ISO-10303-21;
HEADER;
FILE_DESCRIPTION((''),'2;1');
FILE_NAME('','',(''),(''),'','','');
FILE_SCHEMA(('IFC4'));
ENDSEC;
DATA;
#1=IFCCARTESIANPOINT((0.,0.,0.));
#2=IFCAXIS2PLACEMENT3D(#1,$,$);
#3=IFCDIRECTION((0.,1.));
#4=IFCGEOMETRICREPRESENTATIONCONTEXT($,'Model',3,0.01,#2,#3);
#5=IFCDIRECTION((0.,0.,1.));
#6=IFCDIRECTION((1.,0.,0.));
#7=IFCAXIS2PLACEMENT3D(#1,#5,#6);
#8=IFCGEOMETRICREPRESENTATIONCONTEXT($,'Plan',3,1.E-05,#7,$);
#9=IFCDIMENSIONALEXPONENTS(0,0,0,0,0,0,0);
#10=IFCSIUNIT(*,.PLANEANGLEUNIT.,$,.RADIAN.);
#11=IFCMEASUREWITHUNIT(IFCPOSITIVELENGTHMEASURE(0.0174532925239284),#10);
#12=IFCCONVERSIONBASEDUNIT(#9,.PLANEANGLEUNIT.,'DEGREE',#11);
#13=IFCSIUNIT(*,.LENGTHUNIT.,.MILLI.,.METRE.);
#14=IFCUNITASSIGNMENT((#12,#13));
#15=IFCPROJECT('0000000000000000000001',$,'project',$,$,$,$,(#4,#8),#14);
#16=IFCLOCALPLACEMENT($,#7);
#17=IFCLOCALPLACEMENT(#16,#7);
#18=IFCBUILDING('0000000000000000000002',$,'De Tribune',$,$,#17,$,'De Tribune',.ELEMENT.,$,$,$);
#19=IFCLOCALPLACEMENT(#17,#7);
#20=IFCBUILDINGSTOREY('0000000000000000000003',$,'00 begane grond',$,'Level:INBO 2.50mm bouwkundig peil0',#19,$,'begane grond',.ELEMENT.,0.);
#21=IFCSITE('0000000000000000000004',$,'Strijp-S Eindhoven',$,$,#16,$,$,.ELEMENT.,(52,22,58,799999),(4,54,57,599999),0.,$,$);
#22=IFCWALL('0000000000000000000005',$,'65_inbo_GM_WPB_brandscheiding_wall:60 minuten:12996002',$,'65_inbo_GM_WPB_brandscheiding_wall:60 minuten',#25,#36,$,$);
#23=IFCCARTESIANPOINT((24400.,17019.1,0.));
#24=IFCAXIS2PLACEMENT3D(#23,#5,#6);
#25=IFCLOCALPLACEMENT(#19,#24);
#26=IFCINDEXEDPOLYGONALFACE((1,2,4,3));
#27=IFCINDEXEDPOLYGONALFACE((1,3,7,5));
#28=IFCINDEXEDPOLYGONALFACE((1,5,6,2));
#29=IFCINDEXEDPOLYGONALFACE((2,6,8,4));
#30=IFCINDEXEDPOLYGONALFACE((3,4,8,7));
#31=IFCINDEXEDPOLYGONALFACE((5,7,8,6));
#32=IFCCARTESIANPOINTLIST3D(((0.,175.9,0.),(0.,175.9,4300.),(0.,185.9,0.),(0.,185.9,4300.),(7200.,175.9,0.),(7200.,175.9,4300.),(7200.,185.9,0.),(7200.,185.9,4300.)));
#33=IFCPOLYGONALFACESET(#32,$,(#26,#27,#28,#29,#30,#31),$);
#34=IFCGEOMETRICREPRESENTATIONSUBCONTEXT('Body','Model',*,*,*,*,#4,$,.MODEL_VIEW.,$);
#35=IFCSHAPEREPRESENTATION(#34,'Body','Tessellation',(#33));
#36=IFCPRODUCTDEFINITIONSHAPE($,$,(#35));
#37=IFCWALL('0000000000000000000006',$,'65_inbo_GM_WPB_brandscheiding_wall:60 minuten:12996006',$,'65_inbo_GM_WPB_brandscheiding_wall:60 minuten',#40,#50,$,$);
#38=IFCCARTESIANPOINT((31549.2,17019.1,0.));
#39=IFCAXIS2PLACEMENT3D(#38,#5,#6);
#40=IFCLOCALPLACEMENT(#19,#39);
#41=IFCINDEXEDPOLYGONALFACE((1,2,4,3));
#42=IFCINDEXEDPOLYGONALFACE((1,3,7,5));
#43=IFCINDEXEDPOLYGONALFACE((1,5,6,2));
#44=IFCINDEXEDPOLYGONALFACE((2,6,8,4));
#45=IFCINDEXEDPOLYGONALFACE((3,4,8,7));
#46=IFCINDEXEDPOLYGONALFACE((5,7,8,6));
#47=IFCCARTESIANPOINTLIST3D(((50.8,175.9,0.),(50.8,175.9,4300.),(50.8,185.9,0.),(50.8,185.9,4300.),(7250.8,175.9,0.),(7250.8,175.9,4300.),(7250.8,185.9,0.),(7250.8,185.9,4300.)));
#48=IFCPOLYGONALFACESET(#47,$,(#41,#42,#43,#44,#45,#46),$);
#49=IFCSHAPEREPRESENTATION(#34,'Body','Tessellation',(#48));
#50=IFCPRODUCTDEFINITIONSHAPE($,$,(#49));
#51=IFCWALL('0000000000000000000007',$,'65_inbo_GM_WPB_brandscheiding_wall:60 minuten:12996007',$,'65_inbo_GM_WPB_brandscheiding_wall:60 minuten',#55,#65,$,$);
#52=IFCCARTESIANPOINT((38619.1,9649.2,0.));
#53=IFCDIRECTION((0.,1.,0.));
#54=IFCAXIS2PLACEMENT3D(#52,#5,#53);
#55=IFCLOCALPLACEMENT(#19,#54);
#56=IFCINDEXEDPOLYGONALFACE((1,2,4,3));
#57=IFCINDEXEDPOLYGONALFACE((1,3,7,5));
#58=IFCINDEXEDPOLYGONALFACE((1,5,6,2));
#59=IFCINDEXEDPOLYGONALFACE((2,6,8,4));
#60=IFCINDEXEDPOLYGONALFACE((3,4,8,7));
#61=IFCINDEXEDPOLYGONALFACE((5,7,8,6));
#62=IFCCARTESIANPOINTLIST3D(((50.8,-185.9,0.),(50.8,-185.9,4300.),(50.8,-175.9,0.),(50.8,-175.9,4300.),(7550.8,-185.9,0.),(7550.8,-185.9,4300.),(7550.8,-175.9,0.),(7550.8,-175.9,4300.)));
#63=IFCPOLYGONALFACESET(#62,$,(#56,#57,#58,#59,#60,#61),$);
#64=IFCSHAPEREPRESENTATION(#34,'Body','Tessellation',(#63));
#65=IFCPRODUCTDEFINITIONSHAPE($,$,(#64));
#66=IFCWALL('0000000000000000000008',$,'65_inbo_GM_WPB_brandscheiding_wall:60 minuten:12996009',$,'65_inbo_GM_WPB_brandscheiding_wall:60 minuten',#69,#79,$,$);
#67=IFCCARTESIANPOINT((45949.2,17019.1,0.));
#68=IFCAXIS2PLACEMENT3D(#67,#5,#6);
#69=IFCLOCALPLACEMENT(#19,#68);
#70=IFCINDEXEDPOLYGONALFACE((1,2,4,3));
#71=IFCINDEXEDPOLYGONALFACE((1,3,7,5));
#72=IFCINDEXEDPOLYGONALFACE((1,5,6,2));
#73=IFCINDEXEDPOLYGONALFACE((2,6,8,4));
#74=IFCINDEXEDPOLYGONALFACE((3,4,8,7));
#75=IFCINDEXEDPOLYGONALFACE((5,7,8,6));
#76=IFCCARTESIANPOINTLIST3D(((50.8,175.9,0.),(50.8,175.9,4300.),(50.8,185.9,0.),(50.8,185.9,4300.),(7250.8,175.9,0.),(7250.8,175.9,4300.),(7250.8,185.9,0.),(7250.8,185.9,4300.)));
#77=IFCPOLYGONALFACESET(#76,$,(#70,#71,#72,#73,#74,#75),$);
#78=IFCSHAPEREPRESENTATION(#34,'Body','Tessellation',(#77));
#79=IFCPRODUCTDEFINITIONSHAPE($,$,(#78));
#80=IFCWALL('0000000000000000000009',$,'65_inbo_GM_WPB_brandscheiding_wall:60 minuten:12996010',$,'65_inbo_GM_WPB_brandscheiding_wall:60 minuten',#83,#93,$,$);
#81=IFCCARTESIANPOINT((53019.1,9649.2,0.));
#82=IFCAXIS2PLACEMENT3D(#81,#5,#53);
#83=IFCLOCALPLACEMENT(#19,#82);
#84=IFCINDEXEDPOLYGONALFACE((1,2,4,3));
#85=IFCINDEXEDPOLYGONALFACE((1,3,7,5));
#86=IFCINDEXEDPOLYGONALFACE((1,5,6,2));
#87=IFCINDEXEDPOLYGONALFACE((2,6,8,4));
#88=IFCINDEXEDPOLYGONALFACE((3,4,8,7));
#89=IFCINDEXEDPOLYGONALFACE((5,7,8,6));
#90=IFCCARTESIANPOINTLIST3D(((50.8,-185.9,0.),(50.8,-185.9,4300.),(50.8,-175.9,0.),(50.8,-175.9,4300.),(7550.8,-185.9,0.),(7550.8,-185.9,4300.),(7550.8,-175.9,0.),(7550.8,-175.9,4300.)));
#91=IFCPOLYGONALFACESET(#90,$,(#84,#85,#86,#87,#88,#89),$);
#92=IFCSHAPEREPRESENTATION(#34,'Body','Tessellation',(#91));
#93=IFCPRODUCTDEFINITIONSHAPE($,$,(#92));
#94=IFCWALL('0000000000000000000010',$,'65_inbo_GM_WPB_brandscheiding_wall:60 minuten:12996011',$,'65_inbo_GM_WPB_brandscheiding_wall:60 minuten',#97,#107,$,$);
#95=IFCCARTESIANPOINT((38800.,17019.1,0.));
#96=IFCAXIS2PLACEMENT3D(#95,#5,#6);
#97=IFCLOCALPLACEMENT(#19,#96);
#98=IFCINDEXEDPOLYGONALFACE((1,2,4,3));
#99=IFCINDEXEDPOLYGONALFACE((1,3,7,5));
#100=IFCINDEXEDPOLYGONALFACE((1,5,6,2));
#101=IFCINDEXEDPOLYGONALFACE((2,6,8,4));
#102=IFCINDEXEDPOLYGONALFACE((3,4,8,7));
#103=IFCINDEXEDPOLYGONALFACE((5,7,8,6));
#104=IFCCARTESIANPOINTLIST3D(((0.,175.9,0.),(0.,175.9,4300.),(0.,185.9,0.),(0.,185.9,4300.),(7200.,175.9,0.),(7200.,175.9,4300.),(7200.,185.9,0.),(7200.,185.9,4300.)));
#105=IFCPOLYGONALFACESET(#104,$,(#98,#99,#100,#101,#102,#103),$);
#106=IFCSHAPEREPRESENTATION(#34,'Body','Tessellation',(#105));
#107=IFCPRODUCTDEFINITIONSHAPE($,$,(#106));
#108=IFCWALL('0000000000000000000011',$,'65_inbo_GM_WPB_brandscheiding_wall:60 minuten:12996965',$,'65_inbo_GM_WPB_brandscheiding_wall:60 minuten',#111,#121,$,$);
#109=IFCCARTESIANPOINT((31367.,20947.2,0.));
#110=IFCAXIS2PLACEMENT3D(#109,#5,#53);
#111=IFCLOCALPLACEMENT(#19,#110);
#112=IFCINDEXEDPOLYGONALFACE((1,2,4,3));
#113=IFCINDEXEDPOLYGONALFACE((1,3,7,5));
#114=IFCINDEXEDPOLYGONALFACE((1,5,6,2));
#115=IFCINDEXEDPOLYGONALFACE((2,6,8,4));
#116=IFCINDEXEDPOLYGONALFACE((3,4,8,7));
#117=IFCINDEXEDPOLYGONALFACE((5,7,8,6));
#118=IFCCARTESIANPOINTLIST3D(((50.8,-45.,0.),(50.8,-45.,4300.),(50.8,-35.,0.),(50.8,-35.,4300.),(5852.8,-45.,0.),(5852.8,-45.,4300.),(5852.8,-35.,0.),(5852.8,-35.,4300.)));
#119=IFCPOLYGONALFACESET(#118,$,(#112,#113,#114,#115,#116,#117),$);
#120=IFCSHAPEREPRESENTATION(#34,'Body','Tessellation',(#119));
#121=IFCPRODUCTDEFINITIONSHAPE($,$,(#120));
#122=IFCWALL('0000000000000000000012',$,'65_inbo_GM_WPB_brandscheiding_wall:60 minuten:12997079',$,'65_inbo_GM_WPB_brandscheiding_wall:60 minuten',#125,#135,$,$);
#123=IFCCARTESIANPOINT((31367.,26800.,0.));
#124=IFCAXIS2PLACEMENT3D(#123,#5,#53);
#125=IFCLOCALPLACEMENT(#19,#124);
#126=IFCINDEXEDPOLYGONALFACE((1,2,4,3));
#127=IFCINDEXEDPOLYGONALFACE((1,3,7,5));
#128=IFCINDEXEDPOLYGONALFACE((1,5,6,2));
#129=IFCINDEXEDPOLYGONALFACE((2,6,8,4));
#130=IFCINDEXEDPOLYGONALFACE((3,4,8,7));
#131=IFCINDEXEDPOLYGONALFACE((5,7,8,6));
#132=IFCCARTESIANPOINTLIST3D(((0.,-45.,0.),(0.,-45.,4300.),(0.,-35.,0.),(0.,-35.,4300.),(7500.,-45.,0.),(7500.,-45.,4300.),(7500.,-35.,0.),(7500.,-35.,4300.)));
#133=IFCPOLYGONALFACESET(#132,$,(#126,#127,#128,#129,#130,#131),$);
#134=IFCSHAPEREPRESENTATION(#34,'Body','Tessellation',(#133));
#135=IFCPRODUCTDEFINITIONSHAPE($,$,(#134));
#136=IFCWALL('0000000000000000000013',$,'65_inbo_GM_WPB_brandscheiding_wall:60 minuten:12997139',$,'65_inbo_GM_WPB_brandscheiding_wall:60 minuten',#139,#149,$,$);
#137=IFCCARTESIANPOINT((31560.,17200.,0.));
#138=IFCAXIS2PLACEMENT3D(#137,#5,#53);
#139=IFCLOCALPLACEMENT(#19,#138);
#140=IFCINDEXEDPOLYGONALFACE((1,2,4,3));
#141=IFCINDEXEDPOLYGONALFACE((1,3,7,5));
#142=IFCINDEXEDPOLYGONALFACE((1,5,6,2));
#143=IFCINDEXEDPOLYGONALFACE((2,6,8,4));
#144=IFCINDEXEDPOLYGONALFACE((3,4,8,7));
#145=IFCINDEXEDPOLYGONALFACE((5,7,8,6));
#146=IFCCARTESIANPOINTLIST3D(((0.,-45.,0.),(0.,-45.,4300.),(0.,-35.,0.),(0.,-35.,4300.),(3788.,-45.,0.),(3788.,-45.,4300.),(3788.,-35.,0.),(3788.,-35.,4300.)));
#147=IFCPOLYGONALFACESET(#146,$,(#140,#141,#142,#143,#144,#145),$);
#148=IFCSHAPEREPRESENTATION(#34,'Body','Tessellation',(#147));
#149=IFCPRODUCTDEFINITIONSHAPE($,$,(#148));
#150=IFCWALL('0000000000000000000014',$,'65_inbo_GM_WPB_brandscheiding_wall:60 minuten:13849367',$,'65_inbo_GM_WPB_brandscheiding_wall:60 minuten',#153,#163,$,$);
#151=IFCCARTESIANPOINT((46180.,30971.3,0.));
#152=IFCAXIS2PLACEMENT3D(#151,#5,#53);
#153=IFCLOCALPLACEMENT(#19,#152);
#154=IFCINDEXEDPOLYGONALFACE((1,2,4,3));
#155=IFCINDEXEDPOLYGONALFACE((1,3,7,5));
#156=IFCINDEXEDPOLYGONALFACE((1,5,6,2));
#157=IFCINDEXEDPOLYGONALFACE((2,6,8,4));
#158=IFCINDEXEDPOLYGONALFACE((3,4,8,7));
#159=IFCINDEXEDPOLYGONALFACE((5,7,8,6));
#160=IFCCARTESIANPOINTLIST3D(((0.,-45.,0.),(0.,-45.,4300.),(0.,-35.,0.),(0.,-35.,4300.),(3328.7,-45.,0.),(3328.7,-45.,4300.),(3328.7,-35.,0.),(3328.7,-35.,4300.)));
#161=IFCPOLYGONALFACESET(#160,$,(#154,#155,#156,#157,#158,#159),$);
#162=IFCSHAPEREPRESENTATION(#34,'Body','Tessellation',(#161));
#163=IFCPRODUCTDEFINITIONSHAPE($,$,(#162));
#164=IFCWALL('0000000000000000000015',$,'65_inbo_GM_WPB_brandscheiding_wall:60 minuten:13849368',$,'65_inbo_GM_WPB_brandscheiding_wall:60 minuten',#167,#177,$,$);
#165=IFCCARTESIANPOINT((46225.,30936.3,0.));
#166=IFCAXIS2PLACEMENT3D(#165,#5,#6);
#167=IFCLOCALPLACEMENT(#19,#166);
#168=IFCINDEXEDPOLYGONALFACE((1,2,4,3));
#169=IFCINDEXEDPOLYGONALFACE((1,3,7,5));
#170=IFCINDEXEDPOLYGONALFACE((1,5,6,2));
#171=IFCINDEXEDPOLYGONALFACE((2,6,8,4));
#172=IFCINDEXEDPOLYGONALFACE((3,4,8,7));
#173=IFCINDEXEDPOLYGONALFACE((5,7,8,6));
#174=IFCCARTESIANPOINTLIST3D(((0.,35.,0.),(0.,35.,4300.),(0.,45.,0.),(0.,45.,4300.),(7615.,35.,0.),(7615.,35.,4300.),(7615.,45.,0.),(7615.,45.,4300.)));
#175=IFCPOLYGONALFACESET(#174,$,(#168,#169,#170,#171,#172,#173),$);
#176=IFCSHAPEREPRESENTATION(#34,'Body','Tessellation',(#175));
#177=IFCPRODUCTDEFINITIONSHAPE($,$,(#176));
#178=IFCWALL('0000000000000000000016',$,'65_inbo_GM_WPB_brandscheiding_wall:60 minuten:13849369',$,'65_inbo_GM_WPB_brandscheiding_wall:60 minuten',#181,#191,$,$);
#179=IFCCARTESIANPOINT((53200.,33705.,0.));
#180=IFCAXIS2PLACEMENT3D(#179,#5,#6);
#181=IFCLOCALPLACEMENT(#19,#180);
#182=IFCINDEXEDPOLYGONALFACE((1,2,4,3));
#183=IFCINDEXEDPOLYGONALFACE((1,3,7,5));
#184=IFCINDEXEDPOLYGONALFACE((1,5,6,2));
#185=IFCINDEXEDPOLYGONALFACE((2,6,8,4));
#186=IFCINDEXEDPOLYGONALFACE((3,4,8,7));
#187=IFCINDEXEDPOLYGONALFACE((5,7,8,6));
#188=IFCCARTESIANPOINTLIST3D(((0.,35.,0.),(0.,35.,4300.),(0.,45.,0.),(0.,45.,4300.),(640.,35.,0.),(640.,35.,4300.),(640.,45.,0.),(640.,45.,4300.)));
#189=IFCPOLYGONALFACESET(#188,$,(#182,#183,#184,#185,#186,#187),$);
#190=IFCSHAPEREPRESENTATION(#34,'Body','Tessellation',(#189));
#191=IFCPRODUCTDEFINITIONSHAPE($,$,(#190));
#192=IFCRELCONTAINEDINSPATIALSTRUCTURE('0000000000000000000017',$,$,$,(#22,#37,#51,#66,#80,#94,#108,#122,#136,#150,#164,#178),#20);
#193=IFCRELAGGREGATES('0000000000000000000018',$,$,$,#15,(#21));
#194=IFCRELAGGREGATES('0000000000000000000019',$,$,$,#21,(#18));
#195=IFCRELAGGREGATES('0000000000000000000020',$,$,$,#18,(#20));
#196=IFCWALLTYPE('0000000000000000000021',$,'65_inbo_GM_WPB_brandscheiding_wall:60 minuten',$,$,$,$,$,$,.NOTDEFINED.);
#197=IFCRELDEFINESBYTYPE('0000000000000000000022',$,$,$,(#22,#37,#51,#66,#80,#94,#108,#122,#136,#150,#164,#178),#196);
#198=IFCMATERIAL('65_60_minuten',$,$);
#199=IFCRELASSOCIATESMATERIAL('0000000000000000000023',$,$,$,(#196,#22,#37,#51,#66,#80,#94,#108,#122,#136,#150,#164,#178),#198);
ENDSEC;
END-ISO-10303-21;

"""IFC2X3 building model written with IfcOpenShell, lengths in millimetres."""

from ifc_helpers import new_model, entity, si_unit, converted_unit, direction, frame, frame_2d, origin, origin_with_axes, origin_2d_with_axis, place, context, subcontext, project, spatial, rectangle, extrude, material, type_object, element, save


model = new_model("IFC2X3")

# Units and contexts
model_context = context("Model", 3, precision=0.01, world=origin(), true_north=direction((0.0, 1.0)))
plan_context = context("Plan", 3, precision=1e-05, world=origin_with_axes())
body_context = subcontext(model_context, "Body", "Model", "MODEL_VIEW")
ifc_project = project(units=[converted_unit("PLANEANGLEUNIT", "DEGREE", entity("IfcPositiveLengthMeasure", 0.0174532925239284), si_unit("PLANEANGLEUNIT", "RADIAN"), dimensions=[0, 0, 0, 0, 0, 0, 0]), si_unit("LENGTHUNIT", "METRE", prefix="MILLI")], contexts=[model_context, plan_context])

# Site, building, storey
site_placement = place(None, origin_with_axes())
site = spatial("IfcSite", under=ifc_project, at=site_placement, Name="Strijp-S Eindhoven", CompositionType="ELEMENT", RefLatitude=(52, 22, 58, 799999), RefLongitude=(4, 54, 57, 599999), RefElevation=0.0)
building_placement = place(site_placement, origin_with_axes())
building = spatial("IfcBuilding", under=site, at=building_placement, Name="De Tribune", LongName="De Tribune", CompositionType="ELEMENT")
storey_placement = place(building_placement, origin_with_axes())
storey = spatial("IfcBuildingStorey", under=building, at=storey_placement, Name="00 begane grond", ObjectType="Level:INBO 2.50mm bouwkundig peil0", LongName="begane grond", CompositionType="ELEMENT", Elevation=0.0)

# Walls
ifc_material = material(Name="65_60_minuten")
wall_type = type_object("IfcWallType", Name="65_inbo_GM_WPB_brandscheiding_wall:60 minuten", PredefinedType="NOTDEFINED", material=ifc_material)
wall_1_placement = place(storey_placement, frame((24400.0, 17019.1, 0.0), z_axis=(0.0, 0.0, 1.0), x_axis=(1.0, 0.0, 0.0)))
element("IfcWall", 1, at=wall_1_placement, inside=storey, type_object=wall_type, material=ifc_material, Name="65_inbo_GM_WPB_brandscheiding_wall:60 minuten:12996002", ObjectType="65_inbo_GM_WPB_brandscheiding_wall:60 minuten", context=body_context, shape_type="SweptSolid", body=[
    extrude(rectangle(XDim=10.0, YDim=7200.0, at=frame_2d((0.0, 0.0), x_axis=(1.0, 0.0))), frame((3600.0, 180.9, 0.0), z_axis=(0.0, 0.0, 1.0), x_axis=(0.0, -1.0, 0.0)), (0.0, 0.0, 1.0), 4300.0),
])
wall_2_placement = place(storey_placement, frame((31549.2, 17019.1, 0.0), z_axis=(0.0, 0.0, 1.0), x_axis=(1.0, 0.0, 0.0)))
element("IfcWall", 2, at=wall_2_placement, inside=storey, type_object=wall_type, material=ifc_material, Name="65_inbo_GM_WPB_brandscheiding_wall:60 minuten:12996006", ObjectType="65_inbo_GM_WPB_brandscheiding_wall:60 minuten", context=body_context, shape_type="SweptSolid", body=[
    extrude(rectangle(XDim=7200.0, YDim=10.0, at=origin_2d_with_axis()), frame((3650.8, 180.9, 0.0), z_axis=(0.0, 0.0, 1.0), x_axis=(-1.0, 0.0, 0.0)), (0.0, 0.0, 1.0), 4300.0),
])
wall_3_placement = place(storey_placement, frame((38619.1, 9649.2, 0.0), z_axis=(0.0, 0.0, 1.0), x_axis=(0.0, 1.0, 0.0)))
element("IfcWall", 3, at=wall_3_placement, inside=storey, type_object=wall_type, material=ifc_material, Name="65_inbo_GM_WPB_brandscheiding_wall:60 minuten:12996007", ObjectType="65_inbo_GM_WPB_brandscheiding_wall:60 minuten", context=body_context, shape_type="SweptSolid", body=[
    extrude(rectangle(XDim=10.0, YDim=7500.0, at=frame_2d((0.0, 0.0), x_axis=(1.0, 0.0))), frame((3800.8, -180.9, 0.0), z_axis=(0.0, 0.0, 1.0), x_axis=(0.0, 1.0, 0.0)), (0.0, 0.0, 1.0), 4300.0),
])
wall_4_placement = place(storey_placement, frame((45949.2, 17019.1, 0.0), z_axis=(0.0, 0.0, 1.0), x_axis=(1.0, 0.0, 0.0)))
element("IfcWall", 4, at=wall_4_placement, inside=storey, type_object=wall_type, material=ifc_material, Name="65_inbo_GM_WPB_brandscheiding_wall:60 minuten:12996009", ObjectType="65_inbo_GM_WPB_brandscheiding_wall:60 minuten", context=body_context, shape_type="SweptSolid", body=[
    extrude(rectangle(XDim=7200.0, YDim=10.0, at=origin_2d_with_axis()), frame((3650.8, 180.9, 0.0), z_axis=(0.0, 0.0, 1.0), x_axis=(-1.0, 0.0, 0.0)), (0.0, 0.0, 1.0), 4300.0),
])
wall_5_placement = place(storey_placement, frame((53019.1, 9649.2, 0.0), z_axis=(0.0, 0.0, 1.0), x_axis=(0.0, 1.0, 0.0)))
element("IfcWall", 5, at=wall_5_placement, inside=storey, type_object=wall_type, material=ifc_material, Name="65_inbo_GM_WPB_brandscheiding_wall:60 minuten:12996010", ObjectType="65_inbo_GM_WPB_brandscheiding_wall:60 minuten", context=body_context, shape_type="SweptSolid", body=[
    extrude(rectangle(XDim=10.0, YDim=7500.0, at=frame_2d((0.0, 0.0), x_axis=(1.0, 0.0))), frame((3800.8, -180.9, 0.0), z_axis=(0.0, 0.0, 1.0), x_axis=(0.0, 1.0, 0.0)), (0.0, 0.0, 1.0), 4300.0),
])
wall_6_placement = place(storey_placement, frame((38800.0, 17019.1, 0.0), z_axis=(0.0, 0.0, 1.0), x_axis=(1.0, 0.0, 0.0)))
element("IfcWall", 6, at=wall_6_placement, inside=storey, type_object=wall_type, material=ifc_material, Name="65_inbo_GM_WPB_brandscheiding_wall:60 minuten:12996011", ObjectType="65_inbo_GM_WPB_brandscheiding_wall:60 minuten", context=body_context, shape_type="SweptSolid", body=[
    extrude(rectangle(XDim=10.0, YDim=7200.0, at=origin_2d_with_axis()), frame((3600.0, 180.9, 0.0), z_axis=(0.0, 0.0, 1.0), x_axis=(0.0, -1.0, 0.0)), (0.0, 0.0, 1.0), 4300.0),
])
wall_7_placement = place(storey_placement, frame((31367.0, 20947.2, 0.0), z_axis=(0.0, 0.0, 1.0), x_axis=(0.0, 1.0, 0.0)))
element("IfcWall", 7, at=wall_7_placement, inside=storey, type_object=wall_type, material=ifc_material, Name="65_inbo_GM_WPB_brandscheiding_wall:60 minuten:12996965", ObjectType="65_inbo_GM_WPB_brandscheiding_wall:60 minuten", context=body_context, shape_type="SweptSolid", body=[
    extrude(rectangle(XDim=5802.0, YDim=10.0, at=frame_2d((0.0, 0.0), x_axis=(1.0, 0.0))), frame((2951.8, -40.0, 0.0), z_axis=(0.0, 0.0, 1.0), x_axis=(-1.0, 0.0, 0.0)), (0.0, 0.0, 1.0), 4300.0),
])
wall_8_placement = place(storey_placement, frame((31367.0, 26800.0, 0.0), z_axis=(0.0, 0.0, 1.0), x_axis=(0.0, 1.0, 0.0)))
element("IfcWall", 8, at=wall_8_placement, inside=storey, type_object=wall_type, material=ifc_material, Name="65_inbo_GM_WPB_brandscheiding_wall:60 minuten:12997079", ObjectType="65_inbo_GM_WPB_brandscheiding_wall:60 minuten", context=body_context, shape_type="SweptSolid", body=[
    extrude(rectangle(XDim=10.0, YDim=7500.0, at=frame_2d((0.0, 0.0), x_axis=(1.0, 0.0))), frame((3750.0, -40.0, 0.0), z_axis=(0.0, 0.0, 1.0), x_axis=(0.0, -1.0, 0.0)), (0.0, 0.0, 1.0), 4300.0),
])
wall_9_placement = place(storey_placement, frame((31560.0, 17200.0, 0.0), z_axis=(0.0, 0.0, 1.0), x_axis=(0.0, 1.0, 0.0)))
element("IfcWall", 9, at=wall_9_placement, inside=storey, type_object=wall_type, material=ifc_material, Name="65_inbo_GM_WPB_brandscheiding_wall:60 minuten:12997139", ObjectType="65_inbo_GM_WPB_brandscheiding_wall:60 minuten", context=body_context, shape_type="SweptSolid", body=[
    extrude(rectangle(XDim=10.0, YDim=3788.0, at=frame_2d((0.0, 0.0), x_axis=(1.0, 0.0))), frame((1894.0, -40.0, 0.0), z_axis=(0.0, 0.0, 1.0), x_axis=(0.0, -1.0, 0.0)), (0.0, 0.0, 1.0), 4300.0),
])
wall_10_placement = place(storey_placement, frame((46180.0, 30971.3, 0.0), z_axis=(0.0, 0.0, 1.0), x_axis=(0.0, 1.0, 0.0)))
element("IfcWall", 10, at=wall_10_placement, inside=storey, type_object=wall_type, material=ifc_material, Name="65_inbo_GM_WPB_brandscheiding_wall:60 minuten:13849367", ObjectType="65_inbo_GM_WPB_brandscheiding_wall:60 minuten", context=body_context, shape_type="SweptSolid", body=[
    extrude(rectangle(XDim=10.0, YDim=3328.7, at=frame_2d((0.0, 0.0), x_axis=(1.0, 0.0))), frame((1664.3, -40.0, 0.0), z_axis=(0.0, 0.0, 1.0), x_axis=(0.0, -1.0, 0.0)), (0.0, 0.0, 1.0), 4300.0),
])
wall_11_placement = place(storey_placement, frame((46225.0, 30936.3, 0.0), z_axis=(0.0, 0.0, 1.0), x_axis=(1.0, 0.0, 0.0)))
element("IfcWall", 11, at=wall_11_placement, inside=storey, type_object=wall_type, material=ifc_material, Name="65_inbo_GM_WPB_brandscheiding_wall:60 minuten:13849368", ObjectType="65_inbo_GM_WPB_brandscheiding_wall:60 minuten", context=body_context, shape_type="SweptSolid", body=[
    extrude(rectangle(XDim=7615.0, YDim=10.0, at=frame_2d((0.0, 0.0), x_axis=(1.0, 0.0))), frame((3807.5, 40.0, 0.0)), (0.0, 0.0, 1.0), 4300.0),
])
wall_12_placement = place(storey_placement, frame((53200.0, 33705.0, 0.0), z_axis=(0.0, 0.0, 1.0), x_axis=(1.0, 0.0, 0.0)))
element("IfcWall", 12, at=wall_12_placement, inside=storey, type_object=wall_type, material=ifc_material, Name="65_inbo_GM_WPB_brandscheiding_wall:60 minuten:13849369", ObjectType="65_inbo_GM_WPB_brandscheiding_wall:60 minuten", context=body_context, shape_type="SweptSolid", body=[
    extrude(rectangle(XDim=640.0, YDim=10.0, at=frame_2d((0.0, 0.0), x_axis=(1.0, 0.0))), frame((320.0, 40.0, 0.0)), (0.0, 0.0, 1.0), 4300.0),
])

save(model, "model.ifc")
